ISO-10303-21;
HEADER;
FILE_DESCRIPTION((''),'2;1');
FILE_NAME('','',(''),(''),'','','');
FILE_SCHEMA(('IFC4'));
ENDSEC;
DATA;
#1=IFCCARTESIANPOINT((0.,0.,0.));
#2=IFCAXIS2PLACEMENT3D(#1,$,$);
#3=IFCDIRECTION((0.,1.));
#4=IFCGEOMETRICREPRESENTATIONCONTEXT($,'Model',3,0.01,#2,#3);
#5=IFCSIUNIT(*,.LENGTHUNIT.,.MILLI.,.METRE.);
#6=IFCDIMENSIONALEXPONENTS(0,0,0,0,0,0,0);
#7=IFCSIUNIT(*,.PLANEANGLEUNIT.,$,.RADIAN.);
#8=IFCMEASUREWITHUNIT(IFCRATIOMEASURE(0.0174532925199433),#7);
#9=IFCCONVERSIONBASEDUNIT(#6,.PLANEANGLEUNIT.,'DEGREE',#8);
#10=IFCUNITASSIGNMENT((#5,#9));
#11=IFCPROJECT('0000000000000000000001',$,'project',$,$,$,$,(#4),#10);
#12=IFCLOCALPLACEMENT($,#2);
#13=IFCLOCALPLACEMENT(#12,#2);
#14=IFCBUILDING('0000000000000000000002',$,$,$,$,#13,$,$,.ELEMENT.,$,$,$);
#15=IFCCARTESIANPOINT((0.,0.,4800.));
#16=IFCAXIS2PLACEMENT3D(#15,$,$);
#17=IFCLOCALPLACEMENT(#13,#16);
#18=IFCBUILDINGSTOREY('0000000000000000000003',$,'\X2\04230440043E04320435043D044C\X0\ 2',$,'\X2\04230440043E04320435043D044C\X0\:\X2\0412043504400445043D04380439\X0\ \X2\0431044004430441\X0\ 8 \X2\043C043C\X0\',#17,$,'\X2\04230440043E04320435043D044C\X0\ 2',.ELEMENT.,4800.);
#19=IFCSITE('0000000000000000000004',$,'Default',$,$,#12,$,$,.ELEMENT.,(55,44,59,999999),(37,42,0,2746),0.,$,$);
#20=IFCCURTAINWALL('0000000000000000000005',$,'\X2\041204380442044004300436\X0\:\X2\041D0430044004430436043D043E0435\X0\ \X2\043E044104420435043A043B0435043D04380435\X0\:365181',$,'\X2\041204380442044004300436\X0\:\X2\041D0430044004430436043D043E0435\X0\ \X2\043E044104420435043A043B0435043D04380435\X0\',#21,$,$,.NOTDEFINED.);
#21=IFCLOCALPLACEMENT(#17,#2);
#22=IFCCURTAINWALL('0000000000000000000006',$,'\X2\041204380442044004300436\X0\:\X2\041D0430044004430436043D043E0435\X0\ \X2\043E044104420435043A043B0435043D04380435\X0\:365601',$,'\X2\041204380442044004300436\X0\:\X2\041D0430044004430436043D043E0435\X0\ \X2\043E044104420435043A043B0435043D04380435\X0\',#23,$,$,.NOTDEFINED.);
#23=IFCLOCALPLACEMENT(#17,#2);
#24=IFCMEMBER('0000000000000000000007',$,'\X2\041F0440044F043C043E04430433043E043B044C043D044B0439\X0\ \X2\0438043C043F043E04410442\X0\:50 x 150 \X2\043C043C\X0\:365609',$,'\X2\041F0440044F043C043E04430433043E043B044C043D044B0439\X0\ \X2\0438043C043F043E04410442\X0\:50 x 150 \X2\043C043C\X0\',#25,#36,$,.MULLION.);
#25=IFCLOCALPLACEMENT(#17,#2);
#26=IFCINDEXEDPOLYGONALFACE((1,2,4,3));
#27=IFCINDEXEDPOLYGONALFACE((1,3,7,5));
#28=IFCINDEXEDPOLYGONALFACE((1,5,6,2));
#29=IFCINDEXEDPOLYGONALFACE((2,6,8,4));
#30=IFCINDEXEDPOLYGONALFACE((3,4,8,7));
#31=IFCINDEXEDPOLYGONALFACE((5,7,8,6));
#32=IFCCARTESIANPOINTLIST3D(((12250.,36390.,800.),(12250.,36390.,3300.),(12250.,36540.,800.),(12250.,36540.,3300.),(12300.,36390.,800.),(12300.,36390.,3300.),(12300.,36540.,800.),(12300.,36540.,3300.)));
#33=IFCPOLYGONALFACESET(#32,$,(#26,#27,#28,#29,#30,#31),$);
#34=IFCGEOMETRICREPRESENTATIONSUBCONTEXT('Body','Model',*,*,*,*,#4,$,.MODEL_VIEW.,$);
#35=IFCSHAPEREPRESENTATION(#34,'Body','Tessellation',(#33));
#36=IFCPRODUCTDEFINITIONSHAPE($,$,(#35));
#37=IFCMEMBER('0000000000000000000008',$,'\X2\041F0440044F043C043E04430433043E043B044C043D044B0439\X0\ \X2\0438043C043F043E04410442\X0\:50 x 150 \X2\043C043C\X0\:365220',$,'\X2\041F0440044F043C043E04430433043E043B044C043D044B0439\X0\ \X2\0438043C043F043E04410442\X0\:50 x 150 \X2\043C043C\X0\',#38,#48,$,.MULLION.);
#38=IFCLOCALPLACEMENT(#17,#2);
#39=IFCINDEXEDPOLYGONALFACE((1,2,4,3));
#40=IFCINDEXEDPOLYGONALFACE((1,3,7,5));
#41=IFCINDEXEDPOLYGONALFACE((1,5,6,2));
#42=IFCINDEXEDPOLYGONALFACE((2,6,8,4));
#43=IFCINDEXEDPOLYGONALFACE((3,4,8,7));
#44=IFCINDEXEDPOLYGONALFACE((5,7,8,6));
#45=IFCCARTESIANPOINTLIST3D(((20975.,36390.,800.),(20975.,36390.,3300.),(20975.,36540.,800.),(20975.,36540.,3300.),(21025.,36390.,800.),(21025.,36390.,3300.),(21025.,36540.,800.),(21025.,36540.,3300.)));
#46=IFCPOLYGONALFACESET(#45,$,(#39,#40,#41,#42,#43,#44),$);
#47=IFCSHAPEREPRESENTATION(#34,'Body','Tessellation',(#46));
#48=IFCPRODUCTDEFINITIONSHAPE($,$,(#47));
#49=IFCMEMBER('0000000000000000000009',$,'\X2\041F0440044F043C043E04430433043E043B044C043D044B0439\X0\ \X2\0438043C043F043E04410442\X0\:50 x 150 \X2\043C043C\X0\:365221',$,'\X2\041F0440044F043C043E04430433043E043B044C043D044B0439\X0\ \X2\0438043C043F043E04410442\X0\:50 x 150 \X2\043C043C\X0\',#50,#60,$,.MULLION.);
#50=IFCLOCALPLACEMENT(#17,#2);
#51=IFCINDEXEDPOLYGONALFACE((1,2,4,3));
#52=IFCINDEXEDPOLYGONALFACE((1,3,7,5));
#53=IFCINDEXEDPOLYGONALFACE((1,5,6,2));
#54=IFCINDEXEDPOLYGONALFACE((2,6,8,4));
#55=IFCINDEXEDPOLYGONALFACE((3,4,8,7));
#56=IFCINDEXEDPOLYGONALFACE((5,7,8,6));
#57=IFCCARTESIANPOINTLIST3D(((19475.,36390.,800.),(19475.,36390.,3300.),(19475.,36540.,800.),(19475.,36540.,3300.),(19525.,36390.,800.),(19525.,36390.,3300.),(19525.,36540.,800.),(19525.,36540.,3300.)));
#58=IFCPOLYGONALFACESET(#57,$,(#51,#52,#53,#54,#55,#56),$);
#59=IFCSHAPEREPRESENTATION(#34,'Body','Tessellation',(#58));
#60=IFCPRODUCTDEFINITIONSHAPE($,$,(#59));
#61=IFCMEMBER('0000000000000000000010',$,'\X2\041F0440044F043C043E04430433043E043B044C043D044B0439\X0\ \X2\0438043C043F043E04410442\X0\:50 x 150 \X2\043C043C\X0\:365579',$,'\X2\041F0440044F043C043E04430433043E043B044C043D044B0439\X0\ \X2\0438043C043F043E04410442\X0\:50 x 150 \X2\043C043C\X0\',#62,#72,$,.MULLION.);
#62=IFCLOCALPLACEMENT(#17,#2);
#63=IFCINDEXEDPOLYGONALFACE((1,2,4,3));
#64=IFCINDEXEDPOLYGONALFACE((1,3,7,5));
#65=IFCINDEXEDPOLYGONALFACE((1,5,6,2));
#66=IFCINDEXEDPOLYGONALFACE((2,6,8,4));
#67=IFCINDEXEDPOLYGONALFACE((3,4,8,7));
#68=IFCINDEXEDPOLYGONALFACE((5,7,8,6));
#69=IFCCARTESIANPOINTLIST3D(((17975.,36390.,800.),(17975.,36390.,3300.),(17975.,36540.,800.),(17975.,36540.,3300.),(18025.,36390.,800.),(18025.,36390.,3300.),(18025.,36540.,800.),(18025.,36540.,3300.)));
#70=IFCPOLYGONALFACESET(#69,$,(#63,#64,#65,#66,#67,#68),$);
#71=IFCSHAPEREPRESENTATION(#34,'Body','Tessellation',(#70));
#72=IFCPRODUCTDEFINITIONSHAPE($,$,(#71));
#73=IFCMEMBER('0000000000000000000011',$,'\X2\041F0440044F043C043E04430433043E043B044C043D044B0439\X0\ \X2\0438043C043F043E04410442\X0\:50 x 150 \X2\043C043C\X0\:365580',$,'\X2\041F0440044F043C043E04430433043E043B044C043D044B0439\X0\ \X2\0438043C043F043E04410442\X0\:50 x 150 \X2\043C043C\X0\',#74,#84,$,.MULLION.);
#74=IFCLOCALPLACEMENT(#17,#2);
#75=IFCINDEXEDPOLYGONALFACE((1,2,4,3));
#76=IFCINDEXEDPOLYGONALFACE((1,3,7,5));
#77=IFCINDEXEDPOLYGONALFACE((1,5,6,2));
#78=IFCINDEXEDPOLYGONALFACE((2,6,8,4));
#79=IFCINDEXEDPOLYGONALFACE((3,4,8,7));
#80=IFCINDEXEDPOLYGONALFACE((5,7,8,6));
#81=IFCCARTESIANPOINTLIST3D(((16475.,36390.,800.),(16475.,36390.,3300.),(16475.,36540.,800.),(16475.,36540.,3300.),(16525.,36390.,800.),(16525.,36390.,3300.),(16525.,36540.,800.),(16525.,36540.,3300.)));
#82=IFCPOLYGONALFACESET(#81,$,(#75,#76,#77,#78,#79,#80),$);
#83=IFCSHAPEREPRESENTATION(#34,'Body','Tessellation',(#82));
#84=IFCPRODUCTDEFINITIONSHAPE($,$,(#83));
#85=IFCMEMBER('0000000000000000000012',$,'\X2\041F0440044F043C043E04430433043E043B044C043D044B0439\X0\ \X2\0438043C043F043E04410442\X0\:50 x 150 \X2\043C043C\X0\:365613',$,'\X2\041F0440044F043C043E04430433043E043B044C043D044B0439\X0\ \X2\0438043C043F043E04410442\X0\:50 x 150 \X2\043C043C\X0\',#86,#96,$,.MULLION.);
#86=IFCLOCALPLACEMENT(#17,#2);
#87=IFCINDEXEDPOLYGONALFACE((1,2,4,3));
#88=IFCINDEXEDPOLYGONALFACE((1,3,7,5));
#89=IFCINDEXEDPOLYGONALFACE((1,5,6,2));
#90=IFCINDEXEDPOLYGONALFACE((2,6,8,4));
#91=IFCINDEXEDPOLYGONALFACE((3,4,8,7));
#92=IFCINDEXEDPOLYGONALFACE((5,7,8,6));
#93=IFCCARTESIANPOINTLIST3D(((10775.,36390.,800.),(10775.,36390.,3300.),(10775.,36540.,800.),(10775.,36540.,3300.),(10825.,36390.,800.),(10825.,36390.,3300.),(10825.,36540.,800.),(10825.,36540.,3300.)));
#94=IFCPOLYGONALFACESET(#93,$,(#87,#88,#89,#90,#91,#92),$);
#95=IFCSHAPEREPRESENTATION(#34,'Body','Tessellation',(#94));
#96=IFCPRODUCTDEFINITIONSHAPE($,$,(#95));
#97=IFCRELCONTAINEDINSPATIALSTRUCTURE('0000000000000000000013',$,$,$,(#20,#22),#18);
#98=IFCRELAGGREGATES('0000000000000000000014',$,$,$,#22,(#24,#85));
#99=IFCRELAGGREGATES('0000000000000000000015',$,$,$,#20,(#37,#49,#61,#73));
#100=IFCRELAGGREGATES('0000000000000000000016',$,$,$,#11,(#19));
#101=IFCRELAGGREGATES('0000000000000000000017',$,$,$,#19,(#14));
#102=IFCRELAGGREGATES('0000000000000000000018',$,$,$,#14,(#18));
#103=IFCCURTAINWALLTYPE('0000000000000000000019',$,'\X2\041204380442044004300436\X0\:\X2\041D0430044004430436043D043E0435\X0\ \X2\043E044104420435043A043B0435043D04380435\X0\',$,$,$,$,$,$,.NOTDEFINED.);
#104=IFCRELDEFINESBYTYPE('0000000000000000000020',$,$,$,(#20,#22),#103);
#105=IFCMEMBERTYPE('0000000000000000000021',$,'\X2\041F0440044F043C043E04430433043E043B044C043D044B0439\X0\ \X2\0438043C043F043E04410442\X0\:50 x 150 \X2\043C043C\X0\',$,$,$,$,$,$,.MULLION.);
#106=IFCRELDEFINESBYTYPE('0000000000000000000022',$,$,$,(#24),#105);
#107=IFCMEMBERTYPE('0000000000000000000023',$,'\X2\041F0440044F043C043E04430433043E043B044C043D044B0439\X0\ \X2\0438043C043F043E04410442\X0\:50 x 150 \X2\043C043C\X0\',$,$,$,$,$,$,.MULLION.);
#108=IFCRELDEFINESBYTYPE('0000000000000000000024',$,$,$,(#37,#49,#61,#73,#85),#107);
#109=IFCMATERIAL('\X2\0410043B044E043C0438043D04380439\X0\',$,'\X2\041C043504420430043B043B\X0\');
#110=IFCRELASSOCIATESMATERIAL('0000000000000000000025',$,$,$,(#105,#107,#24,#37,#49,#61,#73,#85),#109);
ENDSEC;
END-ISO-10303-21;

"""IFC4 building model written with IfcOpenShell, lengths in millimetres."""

from ifc_helpers import new_model, entity, si_unit, converted_unit, direction, frame, origin, origin_2d_with_axis, place, context, subcontext, project, spatial, rectangle, extrude, source, transform, mapped, material, material_profile, profile_set, profile_usage, type_object, type_shapes, element, aggregate, save


model = new_model("IFC4")

# Units and contexts
model_context = context("Model", 3, precision=0.01, world=origin(), true_north=direction((0.0, 1.0)))
body_context = subcontext(model_context, "Body", "Model", "MODEL_VIEW")
ifc_project = project(units=[si_unit("LENGTHUNIT", "METRE", prefix="MILLI"), converted_unit("PLANEANGLEUNIT", "DEGREE", entity("IfcRatioMeasure", 0.0174532925199433), si_unit("PLANEANGLEUNIT", "RADIAN"), dimensions=[0, 0, 0, 0, 0, 0, 0])], contexts=[model_context])

# Site, building, storey
site_placement = place(None, origin())
site = spatial("IfcSite", under=ifc_project, at=site_placement, Name="Default", CompositionType="ELEMENT", RefLatitude=(55, 44, 59, 999999), RefLongitude=(37, 42, 0, 2746), RefElevation=0.0)
building_placement = place(site_placement, origin())
building = spatial("IfcBuilding", under=site, at=building_placement, CompositionType="ELEMENT")
storey_placement = place(building_placement, frame((0.0, 0.0, 4800.0)))
storey = spatial("IfcBuildingStorey", under=building, at=storey_placement, Name="Уровень 2", ObjectType="Уровень:Верхний брус 8 мм", LongName="Уровень 2", CompositionType="ELEMENT", Elevation=4800.0)

# Curtain walls
curtain_wall_type = type_object("IfcCurtainWallType", Name="Витраж:Наружное остекление", PredefinedType="NOTDEFINED")
curtain_wall_1_placement = place(storey_placement, frame((0.0, 0.0, -4800.0)))
curtain_wall_1 = element("IfcCurtainWall", 1, at=curtain_wall_1_placement, inside=storey, type_object=curtain_wall_type, Name="Витраж:Наружное остекление:365181", ObjectType="Витраж:Наружное остекление", PredefinedType="NOTDEFINED")
ifc_material_1 = material(Name="Алюминий", Category="Металл")
ifc_material_profile = material_profile(ifc_material_1, rectangle(XDim=150.0, YDim=50.0, at=origin_2d_with_axis()), Name="50 x 150 мм")
ifc_profile_set = profile_set([ifc_material_profile], Name="50 x 150 мм")
curtain_wall_2_placement = place(storey_placement, frame((0.0, 0.0, -4800.0)))
curtain_wall_2 = element("IfcCurtainWall", 2, at=curtain_wall_2_placement, inside=storey, type_object=curtain_wall_type, Name="Витраж:Наружное остекление:365601", ObjectType="Витраж:Наружное остекление", PredefinedType="NOTDEFINED")

# Members
ifc_profile_usage_1 = profile_usage(ifc_profile_set)
member_type_1 = type_object("IfcMemberType", Name="Прямоугольный импост:50 x 150 мм", PredefinedType="MULLION", material=ifc_profile_set)
shared_shape_1 = source(origin(), body_context, "Body", "SweptSolid", [
    extrude(rectangle(XDim=150.0, YDim=50.0, at=origin_2d_with_axis()), frame((-25.0, 0.0, -2500.0), z_axis=(0.0, 0.0, 1.0), x_axis=(0.0, -1.0, 0.0)), (0.0, 0.0, 1.0), 2500.0),
])
type_shapes(member_type_1, [shared_shape_1])
member_1_placement = place(storey_placement, frame((12300.0, 36465.0, 3300.0)))
member_1 = element("IfcMember", 3, at=member_1_placement, type_object=member_type_1, material=ifc_profile_usage_1, Name="Прямоугольный импост:50 x 150 мм:365609", ObjectType="Прямоугольный импост:50 x 150 мм", PredefinedType="MULLION", context=body_context, shape_type="MappedRepresentation", body=[
    mapped(shared_shape_1, transform((0.0, 0.0, 0.0), scale=1.0)),
])
ifc_profile_usage_2 = profile_usage(ifc_profile_set)
member_type_2 = type_object("IfcMemberType", Name="Прямоугольный импост:50 x 150 мм", PredefinedType="MULLION", material=ifc_profile_set)
shared_shape_2 = source(origin(), body_context, "Body", "SweptSolid", [
    extrude(rectangle(XDim=150.0, YDim=50.0, at=origin_2d_with_axis()), frame((0.0, 0.0, -2500.0), z_axis=(0.0, 0.0, 1.0), x_axis=(0.0, -1.0, 0.0)), (0.0, 0.0, 1.0), 2500.0),
])
type_shapes(member_type_2, [shared_shape_2])
member_2_placement = place(storey_placement, frame((21000.0, 36465.0, 800.0), z_axis=(0.0, 0.0, -1.0), x_axis=(-1.0, 0.0, 0.0)))
member_2 = element("IfcMember", 4, at=member_2_placement, type_object=member_type_2, material=ifc_profile_usage_2, Name="Прямоугольный импост:50 x 150 мм:365220", ObjectType="Прямоугольный импост:50 x 150 мм", PredefinedType="MULLION", context=body_context, shape_type="MappedRepresentation", body=[
    mapped(shared_shape_2, transform((0.0, 0.0, 0.0), scale=1.0)),
])
ifc_profile_usage_3 = profile_usage(ifc_profile_set)
member_3_placement = place(storey_placement, frame((19500.0, 36465.0, 800.0), z_axis=(0.0, 0.0, -1.0), x_axis=(-1.0, 0.0, 0.0)))
member_3 = element("IfcMember", 5, at=member_3_placement, type_object=member_type_2, material=ifc_profile_usage_3, Name="Прямоугольный импост:50 x 150 мм:365221", ObjectType="Прямоугольный импост:50 x 150 мм", PredefinedType="MULLION", context=body_context, shape_type="MappedRepresentation", body=[
    mapped(shared_shape_2, transform((0.0, 0.0, 0.0), scale=1.0)),
])
ifc_profile_usage_4 = profile_usage(ifc_profile_set)
member_4_placement = place(storey_placement, frame((18000.0, 36465.0, 800.0), z_axis=(0.0, 0.0, -1.0), x_axis=(-1.0, 0.0, 0.0)))
member_4 = element("IfcMember", 6, at=member_4_placement, type_object=member_type_2, material=ifc_profile_usage_4, Name="Прямоугольный импост:50 x 150 мм:365579", ObjectType="Прямоугольный импост:50 x 150 мм", PredefinedType="MULLION", context=body_context, shape_type="MappedRepresentation", body=[
    mapped(shared_shape_2, transform((0.0, 0.0, 0.0), scale=1.0)),
])
ifc_profile_usage_5 = profile_usage(ifc_profile_set)
member_5_placement = place(storey_placement, frame((16500.0, 36465.0, 800.0), z_axis=(0.0, 0.0, -1.0), x_axis=(-1.0, 0.0, 0.0)))
member_5 = element("IfcMember", 7, at=member_5_placement, type_object=member_type_2, material=ifc_profile_usage_5, Name="Прямоугольный импост:50 x 150 мм:365580", ObjectType="Прямоугольный импост:50 x 150 мм", PredefinedType="MULLION", context=body_context, shape_type="MappedRepresentation", body=[
    mapped(shared_shape_2, transform((0.0, 0.0, 0.0), scale=1.0)),
])
ifc_profile_usage_6 = profile_usage(ifc_profile_set)
member_6_placement = place(storey_placement, frame((10800.0, 36465.0, 800.0), z_axis=(0.0, 0.0, -1.0), x_axis=(-1.0, 0.0, 0.0)))
member_6 = element("IfcMember", 8, at=member_6_placement, type_object=member_type_2, material=ifc_profile_usage_6, Name="Прямоугольный импост:50 x 150 мм:365613", ObjectType="Прямоугольный импост:50 x 150 мм", PredefinedType="MULLION", context=body_context, shape_type="MappedRepresentation", body=[
    mapped(shared_shape_2, transform((0.0, 0.0, 0.0), scale=1.0)),
])
aggregate(curtain_wall_2, [member_1, member_6])

aggregate(curtain_wall_1, [member_2, member_3, member_4, member_5])

save(model, "model.ifc")
